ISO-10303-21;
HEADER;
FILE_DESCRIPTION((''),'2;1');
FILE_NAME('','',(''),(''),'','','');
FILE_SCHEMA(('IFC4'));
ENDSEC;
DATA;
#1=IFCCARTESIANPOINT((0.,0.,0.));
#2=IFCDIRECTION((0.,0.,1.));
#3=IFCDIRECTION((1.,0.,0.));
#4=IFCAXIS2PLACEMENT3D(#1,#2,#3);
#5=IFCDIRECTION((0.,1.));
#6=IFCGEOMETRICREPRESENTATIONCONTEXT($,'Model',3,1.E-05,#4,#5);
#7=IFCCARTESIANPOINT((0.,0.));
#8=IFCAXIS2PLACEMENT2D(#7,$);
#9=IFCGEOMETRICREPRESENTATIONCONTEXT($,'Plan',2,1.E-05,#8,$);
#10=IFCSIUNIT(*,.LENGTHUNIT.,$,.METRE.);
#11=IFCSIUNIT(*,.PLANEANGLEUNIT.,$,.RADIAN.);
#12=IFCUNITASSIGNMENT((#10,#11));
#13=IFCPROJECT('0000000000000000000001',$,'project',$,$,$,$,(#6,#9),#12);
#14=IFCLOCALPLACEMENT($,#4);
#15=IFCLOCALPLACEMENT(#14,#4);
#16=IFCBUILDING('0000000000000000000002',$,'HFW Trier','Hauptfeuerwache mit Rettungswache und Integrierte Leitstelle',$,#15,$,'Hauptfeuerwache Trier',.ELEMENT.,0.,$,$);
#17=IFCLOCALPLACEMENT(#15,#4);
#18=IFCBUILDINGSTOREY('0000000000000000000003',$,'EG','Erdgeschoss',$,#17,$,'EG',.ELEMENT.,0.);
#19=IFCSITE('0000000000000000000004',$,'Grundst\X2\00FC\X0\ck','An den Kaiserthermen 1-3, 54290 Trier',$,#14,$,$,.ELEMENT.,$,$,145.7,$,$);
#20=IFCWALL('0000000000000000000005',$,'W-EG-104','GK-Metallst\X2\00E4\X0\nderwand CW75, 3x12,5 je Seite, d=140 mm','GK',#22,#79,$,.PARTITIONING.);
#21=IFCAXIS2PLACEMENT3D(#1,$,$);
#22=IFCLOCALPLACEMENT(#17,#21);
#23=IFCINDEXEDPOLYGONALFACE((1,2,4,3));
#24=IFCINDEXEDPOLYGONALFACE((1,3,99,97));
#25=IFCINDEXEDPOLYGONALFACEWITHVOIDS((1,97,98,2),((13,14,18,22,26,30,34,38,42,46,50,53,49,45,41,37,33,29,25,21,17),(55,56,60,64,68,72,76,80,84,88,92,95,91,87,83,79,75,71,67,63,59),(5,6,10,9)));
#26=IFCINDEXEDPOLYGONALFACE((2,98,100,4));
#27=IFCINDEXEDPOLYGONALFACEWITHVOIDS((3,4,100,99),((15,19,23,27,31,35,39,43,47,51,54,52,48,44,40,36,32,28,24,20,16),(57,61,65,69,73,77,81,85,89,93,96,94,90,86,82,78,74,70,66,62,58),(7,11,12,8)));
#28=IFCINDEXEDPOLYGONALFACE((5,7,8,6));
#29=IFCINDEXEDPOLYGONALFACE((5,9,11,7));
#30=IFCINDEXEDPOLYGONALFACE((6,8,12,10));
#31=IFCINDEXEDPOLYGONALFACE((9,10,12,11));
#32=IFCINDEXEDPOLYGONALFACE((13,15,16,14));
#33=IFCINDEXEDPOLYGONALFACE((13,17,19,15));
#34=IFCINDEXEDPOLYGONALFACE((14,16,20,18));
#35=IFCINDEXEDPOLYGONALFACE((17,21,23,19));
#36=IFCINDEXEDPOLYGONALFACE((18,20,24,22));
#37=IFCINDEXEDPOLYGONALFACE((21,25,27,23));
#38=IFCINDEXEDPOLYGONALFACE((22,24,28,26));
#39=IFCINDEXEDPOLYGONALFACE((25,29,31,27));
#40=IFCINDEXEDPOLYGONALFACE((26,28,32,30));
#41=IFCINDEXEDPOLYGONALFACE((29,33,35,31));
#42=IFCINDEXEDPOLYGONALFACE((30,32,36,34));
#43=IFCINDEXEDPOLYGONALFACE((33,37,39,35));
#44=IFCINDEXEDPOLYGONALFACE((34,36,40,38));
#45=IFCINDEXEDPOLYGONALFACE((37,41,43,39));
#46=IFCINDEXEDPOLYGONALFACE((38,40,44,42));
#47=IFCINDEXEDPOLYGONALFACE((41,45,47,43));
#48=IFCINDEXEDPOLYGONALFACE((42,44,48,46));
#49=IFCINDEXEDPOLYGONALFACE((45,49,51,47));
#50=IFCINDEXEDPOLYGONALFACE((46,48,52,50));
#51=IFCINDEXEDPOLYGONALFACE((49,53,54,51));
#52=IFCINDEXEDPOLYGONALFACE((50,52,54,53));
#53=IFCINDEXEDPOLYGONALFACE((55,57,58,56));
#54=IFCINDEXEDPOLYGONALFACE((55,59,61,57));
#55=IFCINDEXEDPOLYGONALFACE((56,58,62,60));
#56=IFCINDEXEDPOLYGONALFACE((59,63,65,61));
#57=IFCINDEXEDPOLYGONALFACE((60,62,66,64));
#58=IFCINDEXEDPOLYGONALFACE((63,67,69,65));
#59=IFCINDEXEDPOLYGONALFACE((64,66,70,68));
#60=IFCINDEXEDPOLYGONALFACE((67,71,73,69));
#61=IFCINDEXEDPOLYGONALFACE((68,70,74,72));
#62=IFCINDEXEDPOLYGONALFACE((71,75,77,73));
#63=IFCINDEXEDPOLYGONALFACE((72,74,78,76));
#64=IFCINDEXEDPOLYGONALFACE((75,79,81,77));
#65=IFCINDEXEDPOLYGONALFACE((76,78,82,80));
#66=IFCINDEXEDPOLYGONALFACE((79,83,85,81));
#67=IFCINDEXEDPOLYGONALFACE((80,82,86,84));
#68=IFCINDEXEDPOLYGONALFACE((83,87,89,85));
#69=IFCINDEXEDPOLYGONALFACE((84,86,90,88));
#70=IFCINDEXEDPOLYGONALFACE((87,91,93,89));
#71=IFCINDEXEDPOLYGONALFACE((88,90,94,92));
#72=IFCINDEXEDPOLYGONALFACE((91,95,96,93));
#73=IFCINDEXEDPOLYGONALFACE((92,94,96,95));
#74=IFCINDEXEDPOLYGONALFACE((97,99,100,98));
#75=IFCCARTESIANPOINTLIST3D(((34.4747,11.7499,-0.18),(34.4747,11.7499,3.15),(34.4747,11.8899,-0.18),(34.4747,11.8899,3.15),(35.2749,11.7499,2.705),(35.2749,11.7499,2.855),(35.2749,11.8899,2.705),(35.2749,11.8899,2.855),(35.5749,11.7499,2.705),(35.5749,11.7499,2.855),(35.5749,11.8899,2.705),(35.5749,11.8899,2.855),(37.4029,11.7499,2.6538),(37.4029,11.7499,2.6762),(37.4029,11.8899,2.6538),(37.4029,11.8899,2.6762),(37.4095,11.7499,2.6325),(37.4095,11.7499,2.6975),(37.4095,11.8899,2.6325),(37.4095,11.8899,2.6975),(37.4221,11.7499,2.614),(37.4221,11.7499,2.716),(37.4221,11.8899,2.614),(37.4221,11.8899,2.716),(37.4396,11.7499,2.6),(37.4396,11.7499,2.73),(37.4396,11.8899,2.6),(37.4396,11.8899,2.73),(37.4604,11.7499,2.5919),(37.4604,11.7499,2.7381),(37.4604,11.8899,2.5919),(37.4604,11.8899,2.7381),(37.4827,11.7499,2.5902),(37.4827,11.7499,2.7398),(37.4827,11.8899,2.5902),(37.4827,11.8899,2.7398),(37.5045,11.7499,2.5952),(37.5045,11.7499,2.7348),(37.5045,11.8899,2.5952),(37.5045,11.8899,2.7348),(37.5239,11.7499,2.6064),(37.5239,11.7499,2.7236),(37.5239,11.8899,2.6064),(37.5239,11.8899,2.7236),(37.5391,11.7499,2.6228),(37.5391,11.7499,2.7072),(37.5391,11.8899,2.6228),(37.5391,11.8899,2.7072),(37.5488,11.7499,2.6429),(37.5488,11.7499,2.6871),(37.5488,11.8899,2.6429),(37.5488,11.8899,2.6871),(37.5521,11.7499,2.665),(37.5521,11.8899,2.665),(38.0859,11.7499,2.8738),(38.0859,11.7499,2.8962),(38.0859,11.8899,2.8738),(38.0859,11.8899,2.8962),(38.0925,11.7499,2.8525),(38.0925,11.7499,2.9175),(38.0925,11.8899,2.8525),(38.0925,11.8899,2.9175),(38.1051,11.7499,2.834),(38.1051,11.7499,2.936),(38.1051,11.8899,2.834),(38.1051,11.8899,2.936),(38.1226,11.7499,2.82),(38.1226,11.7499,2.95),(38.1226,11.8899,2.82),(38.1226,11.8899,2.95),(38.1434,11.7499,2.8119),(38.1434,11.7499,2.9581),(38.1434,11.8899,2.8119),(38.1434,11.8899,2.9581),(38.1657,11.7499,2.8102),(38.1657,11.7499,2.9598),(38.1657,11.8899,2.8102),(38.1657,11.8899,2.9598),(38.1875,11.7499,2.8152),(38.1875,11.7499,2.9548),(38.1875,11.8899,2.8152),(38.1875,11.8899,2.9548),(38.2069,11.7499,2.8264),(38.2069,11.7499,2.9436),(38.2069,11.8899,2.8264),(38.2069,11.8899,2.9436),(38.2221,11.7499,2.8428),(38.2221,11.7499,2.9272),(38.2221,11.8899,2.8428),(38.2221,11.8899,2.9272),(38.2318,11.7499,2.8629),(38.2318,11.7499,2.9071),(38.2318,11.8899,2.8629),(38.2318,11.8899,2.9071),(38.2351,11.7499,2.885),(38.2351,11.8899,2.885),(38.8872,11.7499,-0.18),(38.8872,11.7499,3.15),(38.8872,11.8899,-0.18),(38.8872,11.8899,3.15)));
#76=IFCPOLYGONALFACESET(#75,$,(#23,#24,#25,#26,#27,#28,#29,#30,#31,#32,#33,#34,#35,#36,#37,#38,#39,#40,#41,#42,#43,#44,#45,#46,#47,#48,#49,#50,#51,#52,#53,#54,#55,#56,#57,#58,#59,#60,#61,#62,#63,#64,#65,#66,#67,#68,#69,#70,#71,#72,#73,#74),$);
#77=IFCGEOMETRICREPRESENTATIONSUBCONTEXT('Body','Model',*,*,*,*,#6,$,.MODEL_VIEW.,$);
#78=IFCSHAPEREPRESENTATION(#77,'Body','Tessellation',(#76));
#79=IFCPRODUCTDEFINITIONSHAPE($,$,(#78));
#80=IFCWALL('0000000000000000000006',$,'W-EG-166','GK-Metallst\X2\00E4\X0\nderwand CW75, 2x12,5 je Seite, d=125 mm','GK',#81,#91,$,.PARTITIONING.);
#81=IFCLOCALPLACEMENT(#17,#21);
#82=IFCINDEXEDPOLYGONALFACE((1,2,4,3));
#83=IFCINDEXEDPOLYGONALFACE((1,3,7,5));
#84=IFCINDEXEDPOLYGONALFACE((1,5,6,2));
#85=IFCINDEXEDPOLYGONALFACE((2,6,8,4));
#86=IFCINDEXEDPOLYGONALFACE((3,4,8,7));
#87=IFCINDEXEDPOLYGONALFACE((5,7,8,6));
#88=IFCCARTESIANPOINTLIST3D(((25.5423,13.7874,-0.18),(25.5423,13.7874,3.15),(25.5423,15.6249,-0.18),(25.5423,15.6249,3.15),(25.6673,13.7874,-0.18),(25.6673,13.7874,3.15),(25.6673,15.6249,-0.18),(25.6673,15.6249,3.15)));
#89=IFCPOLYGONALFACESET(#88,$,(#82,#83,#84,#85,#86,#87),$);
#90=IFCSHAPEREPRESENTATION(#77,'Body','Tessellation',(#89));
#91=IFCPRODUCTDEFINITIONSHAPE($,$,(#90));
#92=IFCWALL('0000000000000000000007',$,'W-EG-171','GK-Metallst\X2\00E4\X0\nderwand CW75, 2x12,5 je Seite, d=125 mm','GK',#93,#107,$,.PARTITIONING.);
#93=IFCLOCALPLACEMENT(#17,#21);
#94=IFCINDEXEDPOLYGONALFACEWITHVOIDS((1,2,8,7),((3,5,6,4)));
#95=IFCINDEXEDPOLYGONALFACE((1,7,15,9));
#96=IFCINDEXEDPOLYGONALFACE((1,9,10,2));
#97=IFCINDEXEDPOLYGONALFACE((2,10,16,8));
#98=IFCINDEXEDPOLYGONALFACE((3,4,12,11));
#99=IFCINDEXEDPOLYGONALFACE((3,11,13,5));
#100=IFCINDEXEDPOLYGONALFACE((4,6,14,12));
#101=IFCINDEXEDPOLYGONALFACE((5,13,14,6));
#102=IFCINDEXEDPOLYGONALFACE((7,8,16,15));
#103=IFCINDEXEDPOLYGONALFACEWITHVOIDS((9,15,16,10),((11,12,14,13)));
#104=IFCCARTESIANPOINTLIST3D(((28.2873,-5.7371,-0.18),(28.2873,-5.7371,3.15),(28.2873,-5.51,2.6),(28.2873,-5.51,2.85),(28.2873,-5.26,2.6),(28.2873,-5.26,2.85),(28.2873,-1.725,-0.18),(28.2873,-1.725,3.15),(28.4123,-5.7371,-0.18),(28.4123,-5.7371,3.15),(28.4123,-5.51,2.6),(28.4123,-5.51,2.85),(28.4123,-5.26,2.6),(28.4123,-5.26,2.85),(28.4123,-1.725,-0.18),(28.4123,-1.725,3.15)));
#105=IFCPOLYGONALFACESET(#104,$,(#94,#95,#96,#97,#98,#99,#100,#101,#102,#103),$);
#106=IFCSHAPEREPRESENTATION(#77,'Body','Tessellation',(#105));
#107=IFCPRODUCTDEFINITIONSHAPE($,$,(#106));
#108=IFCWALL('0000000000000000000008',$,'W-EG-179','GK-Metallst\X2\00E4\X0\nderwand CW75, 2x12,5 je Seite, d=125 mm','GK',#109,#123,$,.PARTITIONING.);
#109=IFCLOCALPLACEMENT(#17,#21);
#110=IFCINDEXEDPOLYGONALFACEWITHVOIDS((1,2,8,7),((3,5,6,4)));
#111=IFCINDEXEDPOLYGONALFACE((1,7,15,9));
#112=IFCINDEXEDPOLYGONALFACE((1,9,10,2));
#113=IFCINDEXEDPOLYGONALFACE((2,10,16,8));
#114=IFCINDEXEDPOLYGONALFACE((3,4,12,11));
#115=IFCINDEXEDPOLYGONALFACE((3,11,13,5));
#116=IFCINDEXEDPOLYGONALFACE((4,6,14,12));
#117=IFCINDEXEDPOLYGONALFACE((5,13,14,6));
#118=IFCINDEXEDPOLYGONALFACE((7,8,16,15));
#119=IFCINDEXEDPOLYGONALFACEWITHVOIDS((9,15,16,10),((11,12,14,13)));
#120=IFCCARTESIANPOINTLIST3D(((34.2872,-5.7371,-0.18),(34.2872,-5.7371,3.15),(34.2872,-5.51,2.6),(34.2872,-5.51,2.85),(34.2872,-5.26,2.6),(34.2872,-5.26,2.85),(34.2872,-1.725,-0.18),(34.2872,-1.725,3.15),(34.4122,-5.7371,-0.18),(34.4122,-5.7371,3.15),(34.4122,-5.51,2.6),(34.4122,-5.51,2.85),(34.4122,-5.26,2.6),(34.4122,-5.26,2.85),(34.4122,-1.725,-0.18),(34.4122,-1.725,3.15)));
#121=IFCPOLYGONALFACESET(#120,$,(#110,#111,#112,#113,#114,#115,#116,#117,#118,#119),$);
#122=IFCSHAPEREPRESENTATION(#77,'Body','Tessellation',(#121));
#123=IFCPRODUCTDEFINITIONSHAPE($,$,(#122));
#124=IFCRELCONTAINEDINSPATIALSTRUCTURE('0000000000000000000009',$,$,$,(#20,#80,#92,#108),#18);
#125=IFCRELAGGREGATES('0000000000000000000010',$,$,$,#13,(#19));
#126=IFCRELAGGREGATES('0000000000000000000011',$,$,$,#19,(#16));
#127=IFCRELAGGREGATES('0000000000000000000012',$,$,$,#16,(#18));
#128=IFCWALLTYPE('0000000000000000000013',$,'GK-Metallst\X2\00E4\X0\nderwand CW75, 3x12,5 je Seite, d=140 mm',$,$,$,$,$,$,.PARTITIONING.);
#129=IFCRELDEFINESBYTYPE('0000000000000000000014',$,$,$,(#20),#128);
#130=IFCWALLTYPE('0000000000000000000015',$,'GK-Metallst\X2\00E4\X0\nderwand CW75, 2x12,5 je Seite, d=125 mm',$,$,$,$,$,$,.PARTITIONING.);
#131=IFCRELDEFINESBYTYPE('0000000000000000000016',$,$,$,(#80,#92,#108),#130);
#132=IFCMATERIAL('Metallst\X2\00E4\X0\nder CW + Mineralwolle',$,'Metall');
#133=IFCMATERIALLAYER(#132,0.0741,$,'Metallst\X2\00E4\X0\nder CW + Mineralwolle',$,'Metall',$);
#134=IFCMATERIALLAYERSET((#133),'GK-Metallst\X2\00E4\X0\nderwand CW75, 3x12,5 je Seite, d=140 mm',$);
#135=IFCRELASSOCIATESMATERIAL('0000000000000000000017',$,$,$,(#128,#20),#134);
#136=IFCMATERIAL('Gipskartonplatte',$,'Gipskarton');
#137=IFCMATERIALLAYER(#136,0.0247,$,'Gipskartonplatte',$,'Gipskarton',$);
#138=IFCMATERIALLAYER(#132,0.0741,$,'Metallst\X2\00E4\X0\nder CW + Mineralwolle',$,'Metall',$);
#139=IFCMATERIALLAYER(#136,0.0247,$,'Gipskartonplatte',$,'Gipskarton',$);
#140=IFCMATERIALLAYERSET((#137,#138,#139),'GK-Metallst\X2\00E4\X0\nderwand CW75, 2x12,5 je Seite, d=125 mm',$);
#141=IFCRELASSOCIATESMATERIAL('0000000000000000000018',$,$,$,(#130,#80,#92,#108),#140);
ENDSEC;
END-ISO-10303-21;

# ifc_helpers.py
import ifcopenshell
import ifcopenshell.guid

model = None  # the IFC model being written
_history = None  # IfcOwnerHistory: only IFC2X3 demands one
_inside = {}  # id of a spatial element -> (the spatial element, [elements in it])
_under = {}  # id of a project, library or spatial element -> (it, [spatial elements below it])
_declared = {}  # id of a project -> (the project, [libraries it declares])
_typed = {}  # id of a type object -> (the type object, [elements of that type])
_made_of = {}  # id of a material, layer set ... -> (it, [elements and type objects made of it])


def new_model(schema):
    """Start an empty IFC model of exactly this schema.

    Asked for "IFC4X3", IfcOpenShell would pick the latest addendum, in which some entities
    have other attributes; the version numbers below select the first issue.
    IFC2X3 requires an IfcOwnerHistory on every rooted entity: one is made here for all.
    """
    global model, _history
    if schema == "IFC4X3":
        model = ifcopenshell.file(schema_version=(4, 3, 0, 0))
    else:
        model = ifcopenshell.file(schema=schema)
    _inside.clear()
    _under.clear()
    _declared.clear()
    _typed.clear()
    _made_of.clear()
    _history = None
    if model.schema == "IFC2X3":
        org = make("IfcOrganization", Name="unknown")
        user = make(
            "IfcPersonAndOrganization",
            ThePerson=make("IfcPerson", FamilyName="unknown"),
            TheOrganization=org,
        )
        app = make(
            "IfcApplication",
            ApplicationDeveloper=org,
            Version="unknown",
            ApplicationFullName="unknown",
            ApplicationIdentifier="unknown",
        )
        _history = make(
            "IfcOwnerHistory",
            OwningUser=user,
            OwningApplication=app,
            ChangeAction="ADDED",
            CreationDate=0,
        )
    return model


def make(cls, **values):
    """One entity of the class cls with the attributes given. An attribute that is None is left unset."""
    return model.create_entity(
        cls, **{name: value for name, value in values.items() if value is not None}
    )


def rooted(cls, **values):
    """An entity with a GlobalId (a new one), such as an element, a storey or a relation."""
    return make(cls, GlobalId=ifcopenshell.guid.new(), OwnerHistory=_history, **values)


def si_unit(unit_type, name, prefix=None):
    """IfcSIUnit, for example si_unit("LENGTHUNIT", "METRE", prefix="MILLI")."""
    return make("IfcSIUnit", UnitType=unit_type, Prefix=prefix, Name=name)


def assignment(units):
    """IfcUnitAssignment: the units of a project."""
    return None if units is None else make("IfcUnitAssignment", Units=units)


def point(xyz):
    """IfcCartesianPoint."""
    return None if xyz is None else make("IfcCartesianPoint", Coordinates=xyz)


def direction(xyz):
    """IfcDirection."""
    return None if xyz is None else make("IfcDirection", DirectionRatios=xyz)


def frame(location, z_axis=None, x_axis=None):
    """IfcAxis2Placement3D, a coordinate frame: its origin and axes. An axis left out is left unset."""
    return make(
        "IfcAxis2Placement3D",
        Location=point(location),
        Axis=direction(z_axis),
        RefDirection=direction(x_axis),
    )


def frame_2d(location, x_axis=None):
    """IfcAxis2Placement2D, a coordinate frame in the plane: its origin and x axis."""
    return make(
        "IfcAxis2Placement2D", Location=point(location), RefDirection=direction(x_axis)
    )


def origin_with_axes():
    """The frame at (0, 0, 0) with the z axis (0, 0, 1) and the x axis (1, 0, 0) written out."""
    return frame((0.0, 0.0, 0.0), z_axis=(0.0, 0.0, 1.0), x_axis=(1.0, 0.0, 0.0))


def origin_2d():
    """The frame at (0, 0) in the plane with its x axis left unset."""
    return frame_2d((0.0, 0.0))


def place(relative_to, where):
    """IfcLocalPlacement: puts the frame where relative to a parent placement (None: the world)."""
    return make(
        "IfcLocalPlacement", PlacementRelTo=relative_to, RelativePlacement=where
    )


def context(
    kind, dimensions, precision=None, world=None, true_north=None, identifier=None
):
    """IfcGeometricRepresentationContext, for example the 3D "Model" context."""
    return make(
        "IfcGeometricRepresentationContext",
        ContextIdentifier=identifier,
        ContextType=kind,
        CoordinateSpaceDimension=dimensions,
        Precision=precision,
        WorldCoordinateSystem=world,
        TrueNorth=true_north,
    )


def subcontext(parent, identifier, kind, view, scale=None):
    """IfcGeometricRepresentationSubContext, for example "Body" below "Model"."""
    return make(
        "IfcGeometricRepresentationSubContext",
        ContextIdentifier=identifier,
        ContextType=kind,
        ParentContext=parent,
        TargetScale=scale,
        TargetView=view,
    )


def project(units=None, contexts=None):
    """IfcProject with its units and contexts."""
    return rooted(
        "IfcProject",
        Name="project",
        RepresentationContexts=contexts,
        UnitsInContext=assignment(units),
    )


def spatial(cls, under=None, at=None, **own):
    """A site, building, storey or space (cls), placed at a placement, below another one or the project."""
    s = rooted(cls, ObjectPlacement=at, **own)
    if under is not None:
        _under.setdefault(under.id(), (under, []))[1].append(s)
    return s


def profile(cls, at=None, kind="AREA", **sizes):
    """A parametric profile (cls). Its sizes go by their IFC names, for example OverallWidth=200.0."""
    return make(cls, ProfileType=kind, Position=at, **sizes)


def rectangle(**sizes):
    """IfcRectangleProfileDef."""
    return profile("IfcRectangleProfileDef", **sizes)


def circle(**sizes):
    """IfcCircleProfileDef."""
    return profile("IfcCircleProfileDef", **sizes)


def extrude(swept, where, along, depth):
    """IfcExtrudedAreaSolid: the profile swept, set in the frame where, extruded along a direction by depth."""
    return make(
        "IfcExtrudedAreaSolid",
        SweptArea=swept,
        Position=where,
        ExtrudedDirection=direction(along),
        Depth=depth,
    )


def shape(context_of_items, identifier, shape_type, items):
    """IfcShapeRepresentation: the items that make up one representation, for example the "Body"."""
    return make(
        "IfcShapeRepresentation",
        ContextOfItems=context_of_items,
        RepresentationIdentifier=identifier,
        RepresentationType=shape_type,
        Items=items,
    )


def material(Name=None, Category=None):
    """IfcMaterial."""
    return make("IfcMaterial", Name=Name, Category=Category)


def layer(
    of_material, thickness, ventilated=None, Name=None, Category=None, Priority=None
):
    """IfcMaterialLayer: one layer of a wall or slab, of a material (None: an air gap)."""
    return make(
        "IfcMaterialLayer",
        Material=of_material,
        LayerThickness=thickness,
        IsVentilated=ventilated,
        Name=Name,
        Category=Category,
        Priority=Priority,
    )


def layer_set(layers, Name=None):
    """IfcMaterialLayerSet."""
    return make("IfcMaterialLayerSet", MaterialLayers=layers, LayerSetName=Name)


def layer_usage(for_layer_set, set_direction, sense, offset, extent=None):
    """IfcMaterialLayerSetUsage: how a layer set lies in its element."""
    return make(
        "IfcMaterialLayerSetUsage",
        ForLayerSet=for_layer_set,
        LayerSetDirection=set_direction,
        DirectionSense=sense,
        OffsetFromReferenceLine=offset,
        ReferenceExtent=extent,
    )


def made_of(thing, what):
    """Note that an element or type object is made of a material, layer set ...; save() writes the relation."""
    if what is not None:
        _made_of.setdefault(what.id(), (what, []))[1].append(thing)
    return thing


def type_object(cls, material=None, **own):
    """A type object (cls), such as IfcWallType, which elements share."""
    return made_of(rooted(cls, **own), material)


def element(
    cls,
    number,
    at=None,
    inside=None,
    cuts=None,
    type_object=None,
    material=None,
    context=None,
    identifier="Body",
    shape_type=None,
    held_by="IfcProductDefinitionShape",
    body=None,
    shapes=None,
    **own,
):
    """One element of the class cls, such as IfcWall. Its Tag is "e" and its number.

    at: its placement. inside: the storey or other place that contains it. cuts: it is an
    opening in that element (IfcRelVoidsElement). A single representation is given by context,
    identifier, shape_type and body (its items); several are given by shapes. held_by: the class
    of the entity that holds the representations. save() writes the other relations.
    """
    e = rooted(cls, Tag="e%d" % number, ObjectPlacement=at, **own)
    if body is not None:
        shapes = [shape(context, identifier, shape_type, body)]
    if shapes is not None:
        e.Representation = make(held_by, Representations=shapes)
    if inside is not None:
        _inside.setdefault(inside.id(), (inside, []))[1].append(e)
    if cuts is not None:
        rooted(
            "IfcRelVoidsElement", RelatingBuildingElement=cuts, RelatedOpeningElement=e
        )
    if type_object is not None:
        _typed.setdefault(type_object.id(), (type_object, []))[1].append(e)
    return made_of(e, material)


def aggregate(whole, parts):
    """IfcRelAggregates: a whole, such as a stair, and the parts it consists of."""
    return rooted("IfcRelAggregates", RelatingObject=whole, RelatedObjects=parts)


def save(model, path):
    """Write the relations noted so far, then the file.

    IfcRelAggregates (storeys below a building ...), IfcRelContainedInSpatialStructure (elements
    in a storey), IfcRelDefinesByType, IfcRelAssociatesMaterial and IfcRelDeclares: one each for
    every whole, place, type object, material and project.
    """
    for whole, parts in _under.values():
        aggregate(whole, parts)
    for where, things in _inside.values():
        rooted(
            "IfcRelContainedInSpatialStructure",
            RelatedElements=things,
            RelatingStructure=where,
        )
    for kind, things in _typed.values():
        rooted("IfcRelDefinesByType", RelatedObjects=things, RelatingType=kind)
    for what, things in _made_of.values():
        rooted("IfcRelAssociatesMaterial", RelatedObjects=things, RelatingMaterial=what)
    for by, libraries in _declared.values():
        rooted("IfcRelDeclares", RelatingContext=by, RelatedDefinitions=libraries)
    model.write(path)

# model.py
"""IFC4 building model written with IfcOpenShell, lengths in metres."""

from ifc_helpers import new_model, si_unit, direction, frame, frame_2d, origin_with_axes, origin_2d, place, context, subcontext, project, spatial, rectangle, circle, extrude, material, layer, layer_set, layer_usage, type_object, element, save


model = new_model("IFC4")

# Units and contexts
model_context = context("Model", 3, precision=1e-05, world=origin_with_axes(), true_north=direction((0.0, 1.0)))
plan_context = context("Plan", 2, precision=1e-05, world=origin_2d())
body_context = subcontext(model_context, "Body", "Model", "MODEL_VIEW")
ifc_project = project(units=[si_unit("LENGTHUNIT", "METRE"), si_unit("PLANEANGLEUNIT", "RADIAN")], contexts=[model_context, plan_context])

# Site, building, storey
site_placement = place(None, origin_with_axes())
site = spatial("IfcSite", under=ifc_project, at=site_placement, Name="Grundstück", Description="An den Kaiserthermen 1-3, 54290 Trier", CompositionType="ELEMENT", RefElevation=145.7)
building_placement = place(site_placement, origin_with_axes())
building = spatial("IfcBuilding", under=site, at=building_placement, Name="HFW Trier", Description="Hauptfeuerwache mit Rettungswache und Integrierte Leitstelle", LongName="Hauptfeuerwache Trier", CompositionType="ELEMENT", ElevationOfRefHeight=0.0)
storey_placement = place(building_placement, origin_with_axes())
storey = spatial("IfcBuildingStorey", under=building, at=storey_placement, Name="EG", Description="Erdgeschoss", LongName="EG", CompositionType="ELEMENT", Elevation=0.0)

# Wall, openings
ifc_material_1 = material(Name="Metallständer CW + Mineralwolle", Category="Metall")
ifc_layer_1 = layer(ifc_material_1, 0.0741, Name="Metallständer CW + Mineralwolle", Category="Metall")
ifc_layer_set_1 = layer_set([ifc_layer_1], Name="GK-Metallständerwand CW75, 3x12,5 je Seite, d=140 mm")
ifc_layer_usage_1 = layer_usage(ifc_layer_set_1, "AXIS2", "POSITIVE", -0.07)
wall_type_1 = type_object("IfcWallType", Name="GK-Metallständerwand CW75, 3x12,5 je Seite, d=140 mm", PredefinedType="PARTITIONING", material=ifc_layer_set_1)
wall_1_placement = place(storey_placement, frame((34.4747, 11.8199, -0.18), z_axis=(0.0, 0.0, 1.0), x_axis=(1.0, 0.0, 0.0)))
wall_1 = element("IfcWall", 1, at=wall_1_placement, inside=storey, type_object=wall_type_1, material=ifc_layer_usage_1, Name="W-EG-104", Description="GK-Metallständerwand CW75, 3x12,5 je Seite, d=140 mm", ObjectType="GK", PredefinedType="PARTITIONING", context=body_context, shape_type="SweptSolid", body=[
    extrude(rectangle(XDim=4.4125, YDim=0.14, at=frame_2d((2.2063, 0.0))), origin_with_axes(), (0.0, 0.0, 1.0), 3.33),
])
opening_1_placement = place(wall_1_placement, origin_with_axes())
element("IfcOpeningElement", 2, at=opening_1_placement, cuts=wall_1, ObjectType="Wanddurchbruch", PredefinedType="OPENING", context=body_context, shape_type="SweptSolid", body=[
    extrude(rectangle(XDim=0.3, YDim=0.24, at=frame_2d((0.9502, 0.0))), frame((0.0, 0.0, 2.885), z_axis=(0.0, 0.0, 1.0), x_axis=(1.0, 0.0, 0.0)), (0.0, 0.0, 1.0), 0.15),
])
opening_2_placement = place(wall_1_placement, origin_with_axes())
element("IfcOpeningElement", 3, at=opening_2_placement, cuts=wall_1, ObjectType="Wanddurchbruch", PredefinedType="OPENING", context=body_context, shape_type="SweptSolid", body=[
    extrude(circle(Radius=0.075, at=origin_2d()), frame((3.0024, -0.12, 2.845), z_axis=(0.0, 1.0, 0.0), x_axis=(1.0, 0.0, 0.0)), (0.0, 0.0, 1.0), 0.24),
])
opening_3_placement = place(wall_1_placement, origin_with_axes())
element("IfcOpeningElement", 4, at=opening_3_placement, cuts=wall_1, ObjectType="Wanddurchbruch", PredefinedType="OPENING", context=body_context, shape_type="SweptSolid", body=[
    extrude(circle(Radius=0.075, at=origin_2d()), frame((3.6854, -0.12, 3.065), z_axis=(0.0, 1.0, 0.0), x_axis=(1.0, 0.0, 0.0)), (0.0, 0.0, 1.0), 0.24),
])

# Wall
ifc_material_2 = material(Name="Gipskartonplatte", Category="Gipskarton")
ifc_layer_2 = layer(ifc_material_2, 0.0247, Name="Gipskartonplatte", Category="Gipskarton")
ifc_layer_3 = layer(ifc_material_1, 0.0741, Name="Metallständer CW + Mineralwolle", Category="Metall")
ifc_layer_4 = layer(ifc_material_2, 0.0247, Name="Gipskartonplatte", Category="Gipskarton")
ifc_layer_set_2 = layer_set([ifc_layer_2, ifc_layer_3, ifc_layer_4], Name="GK-Metallständerwand CW75, 2x12,5 je Seite, d=125 mm")
ifc_layer_usage_2 = layer_usage(ifc_layer_set_2, "AXIS2", "POSITIVE", -0.0625)
wall_type_2 = type_object("IfcWallType", Name="GK-Metallständerwand CW75, 2x12,5 je Seite, d=125 mm", PredefinedType="PARTITIONING", material=ifc_layer_set_2)
wall_2_placement = place(storey_placement, frame((25.6048, 15.6249, -0.18), z_axis=(0.0, 0.0, 1.0), x_axis=(0.0, -1.0, 0.0)))
element("IfcWall", 5, at=wall_2_placement, inside=storey, type_object=wall_type_2, material=ifc_layer_usage_2, Name="W-EG-166", Description="GK-Metallständerwand CW75, 2x12,5 je Seite, d=125 mm", ObjectType="GK", PredefinedType="PARTITIONING", context=body_context, shape_type="SweptSolid", body=[
    extrude(rectangle(XDim=1.8375, YDim=0.125, at=frame_2d((0.9188, 0.0))), origin_with_axes(), (0.0, 0.0, 1.0), 3.33),
])

# Walls, openings
ifc_layer_usage_3 = layer_usage(ifc_layer_set_2, "AXIS2", "POSITIVE", -0.0625)
wall_3_placement = place(storey_placement, frame((28.3498, -1.725, -0.18), z_axis=(0.0, 0.0, 1.0), x_axis=(0.0, -1.0, 0.0)))
wall_3 = element("IfcWall", 6, at=wall_3_placement, inside=storey, type_object=wall_type_2, material=ifc_layer_usage_3, Name="W-EG-171", Description="GK-Metallständerwand CW75, 2x12,5 je Seite, d=125 mm", ObjectType="GK", PredefinedType="PARTITIONING", context=body_context, shape_type="SweptSolid", body=[
    extrude(rectangle(XDim=4.0121, YDim=0.125, at=frame_2d((2.0061, 0.0))), origin_with_axes(), (0.0, 0.0, 1.0), 3.33),
])
opening_4_placement = place(wall_3_placement, origin_with_axes())
element("IfcOpeningElement", 7, at=opening_4_placement, cuts=wall_3, ObjectType="Wanddurchbruch", PredefinedType="OPENING", context=body_context, shape_type="SweptSolid", body=[
    extrude(rectangle(XDim=0.25, YDim=0.225, at=frame_2d((3.66, 0.0))), frame((0.0, 0.0, 2.78), z_axis=(0.0, 0.0, 1.0), x_axis=(1.0, 0.0, 0.0)), (0.0, 0.0, 1.0), 0.25),
])
ifc_layer_usage_4 = layer_usage(ifc_layer_set_2, "AXIS2", "POSITIVE", -0.0625)
wall_4_placement = place(storey_placement, frame((34.3497, -1.725, -0.18), z_axis=(0.0, 0.0, 1.0), x_axis=(0.0, -1.0, 0.0)))
wall_4 = element("IfcWall", 8, at=wall_4_placement, inside=storey, type_object=wall_type_2, material=ifc_layer_usage_4, Name="W-EG-179", Description="GK-Metallständerwand CW75, 2x12,5 je Seite, d=125 mm", ObjectType="GK", PredefinedType="PARTITIONING", context=body_context, shape_type="SweptSolid", body=[
    extrude(rectangle(XDim=4.0121, YDim=0.125, at=frame_2d((2.0061, 0.0))), origin_with_axes(), (0.0, 0.0, 1.0), 3.33),
])
opening_5_placement = place(wall_4_placement, origin_with_axes())
element("IfcOpeningElement", 9, at=opening_5_placement, cuts=wall_4, ObjectType="Wanddurchbruch", PredefinedType="OPENING", context=body_context, shape_type="SweptSolid", body=[
    extrude(rectangle(XDim=0.25, YDim=0.225, at=frame_2d((3.66, 0.0))), frame((0.0, 0.0, 2.78), z_axis=(0.0, 0.0, 1.0), x_axis=(1.0, 0.0, 0.0)), (0.0, 0.0, 1.0), 0.25),
])

save(model, "model.ifc")
